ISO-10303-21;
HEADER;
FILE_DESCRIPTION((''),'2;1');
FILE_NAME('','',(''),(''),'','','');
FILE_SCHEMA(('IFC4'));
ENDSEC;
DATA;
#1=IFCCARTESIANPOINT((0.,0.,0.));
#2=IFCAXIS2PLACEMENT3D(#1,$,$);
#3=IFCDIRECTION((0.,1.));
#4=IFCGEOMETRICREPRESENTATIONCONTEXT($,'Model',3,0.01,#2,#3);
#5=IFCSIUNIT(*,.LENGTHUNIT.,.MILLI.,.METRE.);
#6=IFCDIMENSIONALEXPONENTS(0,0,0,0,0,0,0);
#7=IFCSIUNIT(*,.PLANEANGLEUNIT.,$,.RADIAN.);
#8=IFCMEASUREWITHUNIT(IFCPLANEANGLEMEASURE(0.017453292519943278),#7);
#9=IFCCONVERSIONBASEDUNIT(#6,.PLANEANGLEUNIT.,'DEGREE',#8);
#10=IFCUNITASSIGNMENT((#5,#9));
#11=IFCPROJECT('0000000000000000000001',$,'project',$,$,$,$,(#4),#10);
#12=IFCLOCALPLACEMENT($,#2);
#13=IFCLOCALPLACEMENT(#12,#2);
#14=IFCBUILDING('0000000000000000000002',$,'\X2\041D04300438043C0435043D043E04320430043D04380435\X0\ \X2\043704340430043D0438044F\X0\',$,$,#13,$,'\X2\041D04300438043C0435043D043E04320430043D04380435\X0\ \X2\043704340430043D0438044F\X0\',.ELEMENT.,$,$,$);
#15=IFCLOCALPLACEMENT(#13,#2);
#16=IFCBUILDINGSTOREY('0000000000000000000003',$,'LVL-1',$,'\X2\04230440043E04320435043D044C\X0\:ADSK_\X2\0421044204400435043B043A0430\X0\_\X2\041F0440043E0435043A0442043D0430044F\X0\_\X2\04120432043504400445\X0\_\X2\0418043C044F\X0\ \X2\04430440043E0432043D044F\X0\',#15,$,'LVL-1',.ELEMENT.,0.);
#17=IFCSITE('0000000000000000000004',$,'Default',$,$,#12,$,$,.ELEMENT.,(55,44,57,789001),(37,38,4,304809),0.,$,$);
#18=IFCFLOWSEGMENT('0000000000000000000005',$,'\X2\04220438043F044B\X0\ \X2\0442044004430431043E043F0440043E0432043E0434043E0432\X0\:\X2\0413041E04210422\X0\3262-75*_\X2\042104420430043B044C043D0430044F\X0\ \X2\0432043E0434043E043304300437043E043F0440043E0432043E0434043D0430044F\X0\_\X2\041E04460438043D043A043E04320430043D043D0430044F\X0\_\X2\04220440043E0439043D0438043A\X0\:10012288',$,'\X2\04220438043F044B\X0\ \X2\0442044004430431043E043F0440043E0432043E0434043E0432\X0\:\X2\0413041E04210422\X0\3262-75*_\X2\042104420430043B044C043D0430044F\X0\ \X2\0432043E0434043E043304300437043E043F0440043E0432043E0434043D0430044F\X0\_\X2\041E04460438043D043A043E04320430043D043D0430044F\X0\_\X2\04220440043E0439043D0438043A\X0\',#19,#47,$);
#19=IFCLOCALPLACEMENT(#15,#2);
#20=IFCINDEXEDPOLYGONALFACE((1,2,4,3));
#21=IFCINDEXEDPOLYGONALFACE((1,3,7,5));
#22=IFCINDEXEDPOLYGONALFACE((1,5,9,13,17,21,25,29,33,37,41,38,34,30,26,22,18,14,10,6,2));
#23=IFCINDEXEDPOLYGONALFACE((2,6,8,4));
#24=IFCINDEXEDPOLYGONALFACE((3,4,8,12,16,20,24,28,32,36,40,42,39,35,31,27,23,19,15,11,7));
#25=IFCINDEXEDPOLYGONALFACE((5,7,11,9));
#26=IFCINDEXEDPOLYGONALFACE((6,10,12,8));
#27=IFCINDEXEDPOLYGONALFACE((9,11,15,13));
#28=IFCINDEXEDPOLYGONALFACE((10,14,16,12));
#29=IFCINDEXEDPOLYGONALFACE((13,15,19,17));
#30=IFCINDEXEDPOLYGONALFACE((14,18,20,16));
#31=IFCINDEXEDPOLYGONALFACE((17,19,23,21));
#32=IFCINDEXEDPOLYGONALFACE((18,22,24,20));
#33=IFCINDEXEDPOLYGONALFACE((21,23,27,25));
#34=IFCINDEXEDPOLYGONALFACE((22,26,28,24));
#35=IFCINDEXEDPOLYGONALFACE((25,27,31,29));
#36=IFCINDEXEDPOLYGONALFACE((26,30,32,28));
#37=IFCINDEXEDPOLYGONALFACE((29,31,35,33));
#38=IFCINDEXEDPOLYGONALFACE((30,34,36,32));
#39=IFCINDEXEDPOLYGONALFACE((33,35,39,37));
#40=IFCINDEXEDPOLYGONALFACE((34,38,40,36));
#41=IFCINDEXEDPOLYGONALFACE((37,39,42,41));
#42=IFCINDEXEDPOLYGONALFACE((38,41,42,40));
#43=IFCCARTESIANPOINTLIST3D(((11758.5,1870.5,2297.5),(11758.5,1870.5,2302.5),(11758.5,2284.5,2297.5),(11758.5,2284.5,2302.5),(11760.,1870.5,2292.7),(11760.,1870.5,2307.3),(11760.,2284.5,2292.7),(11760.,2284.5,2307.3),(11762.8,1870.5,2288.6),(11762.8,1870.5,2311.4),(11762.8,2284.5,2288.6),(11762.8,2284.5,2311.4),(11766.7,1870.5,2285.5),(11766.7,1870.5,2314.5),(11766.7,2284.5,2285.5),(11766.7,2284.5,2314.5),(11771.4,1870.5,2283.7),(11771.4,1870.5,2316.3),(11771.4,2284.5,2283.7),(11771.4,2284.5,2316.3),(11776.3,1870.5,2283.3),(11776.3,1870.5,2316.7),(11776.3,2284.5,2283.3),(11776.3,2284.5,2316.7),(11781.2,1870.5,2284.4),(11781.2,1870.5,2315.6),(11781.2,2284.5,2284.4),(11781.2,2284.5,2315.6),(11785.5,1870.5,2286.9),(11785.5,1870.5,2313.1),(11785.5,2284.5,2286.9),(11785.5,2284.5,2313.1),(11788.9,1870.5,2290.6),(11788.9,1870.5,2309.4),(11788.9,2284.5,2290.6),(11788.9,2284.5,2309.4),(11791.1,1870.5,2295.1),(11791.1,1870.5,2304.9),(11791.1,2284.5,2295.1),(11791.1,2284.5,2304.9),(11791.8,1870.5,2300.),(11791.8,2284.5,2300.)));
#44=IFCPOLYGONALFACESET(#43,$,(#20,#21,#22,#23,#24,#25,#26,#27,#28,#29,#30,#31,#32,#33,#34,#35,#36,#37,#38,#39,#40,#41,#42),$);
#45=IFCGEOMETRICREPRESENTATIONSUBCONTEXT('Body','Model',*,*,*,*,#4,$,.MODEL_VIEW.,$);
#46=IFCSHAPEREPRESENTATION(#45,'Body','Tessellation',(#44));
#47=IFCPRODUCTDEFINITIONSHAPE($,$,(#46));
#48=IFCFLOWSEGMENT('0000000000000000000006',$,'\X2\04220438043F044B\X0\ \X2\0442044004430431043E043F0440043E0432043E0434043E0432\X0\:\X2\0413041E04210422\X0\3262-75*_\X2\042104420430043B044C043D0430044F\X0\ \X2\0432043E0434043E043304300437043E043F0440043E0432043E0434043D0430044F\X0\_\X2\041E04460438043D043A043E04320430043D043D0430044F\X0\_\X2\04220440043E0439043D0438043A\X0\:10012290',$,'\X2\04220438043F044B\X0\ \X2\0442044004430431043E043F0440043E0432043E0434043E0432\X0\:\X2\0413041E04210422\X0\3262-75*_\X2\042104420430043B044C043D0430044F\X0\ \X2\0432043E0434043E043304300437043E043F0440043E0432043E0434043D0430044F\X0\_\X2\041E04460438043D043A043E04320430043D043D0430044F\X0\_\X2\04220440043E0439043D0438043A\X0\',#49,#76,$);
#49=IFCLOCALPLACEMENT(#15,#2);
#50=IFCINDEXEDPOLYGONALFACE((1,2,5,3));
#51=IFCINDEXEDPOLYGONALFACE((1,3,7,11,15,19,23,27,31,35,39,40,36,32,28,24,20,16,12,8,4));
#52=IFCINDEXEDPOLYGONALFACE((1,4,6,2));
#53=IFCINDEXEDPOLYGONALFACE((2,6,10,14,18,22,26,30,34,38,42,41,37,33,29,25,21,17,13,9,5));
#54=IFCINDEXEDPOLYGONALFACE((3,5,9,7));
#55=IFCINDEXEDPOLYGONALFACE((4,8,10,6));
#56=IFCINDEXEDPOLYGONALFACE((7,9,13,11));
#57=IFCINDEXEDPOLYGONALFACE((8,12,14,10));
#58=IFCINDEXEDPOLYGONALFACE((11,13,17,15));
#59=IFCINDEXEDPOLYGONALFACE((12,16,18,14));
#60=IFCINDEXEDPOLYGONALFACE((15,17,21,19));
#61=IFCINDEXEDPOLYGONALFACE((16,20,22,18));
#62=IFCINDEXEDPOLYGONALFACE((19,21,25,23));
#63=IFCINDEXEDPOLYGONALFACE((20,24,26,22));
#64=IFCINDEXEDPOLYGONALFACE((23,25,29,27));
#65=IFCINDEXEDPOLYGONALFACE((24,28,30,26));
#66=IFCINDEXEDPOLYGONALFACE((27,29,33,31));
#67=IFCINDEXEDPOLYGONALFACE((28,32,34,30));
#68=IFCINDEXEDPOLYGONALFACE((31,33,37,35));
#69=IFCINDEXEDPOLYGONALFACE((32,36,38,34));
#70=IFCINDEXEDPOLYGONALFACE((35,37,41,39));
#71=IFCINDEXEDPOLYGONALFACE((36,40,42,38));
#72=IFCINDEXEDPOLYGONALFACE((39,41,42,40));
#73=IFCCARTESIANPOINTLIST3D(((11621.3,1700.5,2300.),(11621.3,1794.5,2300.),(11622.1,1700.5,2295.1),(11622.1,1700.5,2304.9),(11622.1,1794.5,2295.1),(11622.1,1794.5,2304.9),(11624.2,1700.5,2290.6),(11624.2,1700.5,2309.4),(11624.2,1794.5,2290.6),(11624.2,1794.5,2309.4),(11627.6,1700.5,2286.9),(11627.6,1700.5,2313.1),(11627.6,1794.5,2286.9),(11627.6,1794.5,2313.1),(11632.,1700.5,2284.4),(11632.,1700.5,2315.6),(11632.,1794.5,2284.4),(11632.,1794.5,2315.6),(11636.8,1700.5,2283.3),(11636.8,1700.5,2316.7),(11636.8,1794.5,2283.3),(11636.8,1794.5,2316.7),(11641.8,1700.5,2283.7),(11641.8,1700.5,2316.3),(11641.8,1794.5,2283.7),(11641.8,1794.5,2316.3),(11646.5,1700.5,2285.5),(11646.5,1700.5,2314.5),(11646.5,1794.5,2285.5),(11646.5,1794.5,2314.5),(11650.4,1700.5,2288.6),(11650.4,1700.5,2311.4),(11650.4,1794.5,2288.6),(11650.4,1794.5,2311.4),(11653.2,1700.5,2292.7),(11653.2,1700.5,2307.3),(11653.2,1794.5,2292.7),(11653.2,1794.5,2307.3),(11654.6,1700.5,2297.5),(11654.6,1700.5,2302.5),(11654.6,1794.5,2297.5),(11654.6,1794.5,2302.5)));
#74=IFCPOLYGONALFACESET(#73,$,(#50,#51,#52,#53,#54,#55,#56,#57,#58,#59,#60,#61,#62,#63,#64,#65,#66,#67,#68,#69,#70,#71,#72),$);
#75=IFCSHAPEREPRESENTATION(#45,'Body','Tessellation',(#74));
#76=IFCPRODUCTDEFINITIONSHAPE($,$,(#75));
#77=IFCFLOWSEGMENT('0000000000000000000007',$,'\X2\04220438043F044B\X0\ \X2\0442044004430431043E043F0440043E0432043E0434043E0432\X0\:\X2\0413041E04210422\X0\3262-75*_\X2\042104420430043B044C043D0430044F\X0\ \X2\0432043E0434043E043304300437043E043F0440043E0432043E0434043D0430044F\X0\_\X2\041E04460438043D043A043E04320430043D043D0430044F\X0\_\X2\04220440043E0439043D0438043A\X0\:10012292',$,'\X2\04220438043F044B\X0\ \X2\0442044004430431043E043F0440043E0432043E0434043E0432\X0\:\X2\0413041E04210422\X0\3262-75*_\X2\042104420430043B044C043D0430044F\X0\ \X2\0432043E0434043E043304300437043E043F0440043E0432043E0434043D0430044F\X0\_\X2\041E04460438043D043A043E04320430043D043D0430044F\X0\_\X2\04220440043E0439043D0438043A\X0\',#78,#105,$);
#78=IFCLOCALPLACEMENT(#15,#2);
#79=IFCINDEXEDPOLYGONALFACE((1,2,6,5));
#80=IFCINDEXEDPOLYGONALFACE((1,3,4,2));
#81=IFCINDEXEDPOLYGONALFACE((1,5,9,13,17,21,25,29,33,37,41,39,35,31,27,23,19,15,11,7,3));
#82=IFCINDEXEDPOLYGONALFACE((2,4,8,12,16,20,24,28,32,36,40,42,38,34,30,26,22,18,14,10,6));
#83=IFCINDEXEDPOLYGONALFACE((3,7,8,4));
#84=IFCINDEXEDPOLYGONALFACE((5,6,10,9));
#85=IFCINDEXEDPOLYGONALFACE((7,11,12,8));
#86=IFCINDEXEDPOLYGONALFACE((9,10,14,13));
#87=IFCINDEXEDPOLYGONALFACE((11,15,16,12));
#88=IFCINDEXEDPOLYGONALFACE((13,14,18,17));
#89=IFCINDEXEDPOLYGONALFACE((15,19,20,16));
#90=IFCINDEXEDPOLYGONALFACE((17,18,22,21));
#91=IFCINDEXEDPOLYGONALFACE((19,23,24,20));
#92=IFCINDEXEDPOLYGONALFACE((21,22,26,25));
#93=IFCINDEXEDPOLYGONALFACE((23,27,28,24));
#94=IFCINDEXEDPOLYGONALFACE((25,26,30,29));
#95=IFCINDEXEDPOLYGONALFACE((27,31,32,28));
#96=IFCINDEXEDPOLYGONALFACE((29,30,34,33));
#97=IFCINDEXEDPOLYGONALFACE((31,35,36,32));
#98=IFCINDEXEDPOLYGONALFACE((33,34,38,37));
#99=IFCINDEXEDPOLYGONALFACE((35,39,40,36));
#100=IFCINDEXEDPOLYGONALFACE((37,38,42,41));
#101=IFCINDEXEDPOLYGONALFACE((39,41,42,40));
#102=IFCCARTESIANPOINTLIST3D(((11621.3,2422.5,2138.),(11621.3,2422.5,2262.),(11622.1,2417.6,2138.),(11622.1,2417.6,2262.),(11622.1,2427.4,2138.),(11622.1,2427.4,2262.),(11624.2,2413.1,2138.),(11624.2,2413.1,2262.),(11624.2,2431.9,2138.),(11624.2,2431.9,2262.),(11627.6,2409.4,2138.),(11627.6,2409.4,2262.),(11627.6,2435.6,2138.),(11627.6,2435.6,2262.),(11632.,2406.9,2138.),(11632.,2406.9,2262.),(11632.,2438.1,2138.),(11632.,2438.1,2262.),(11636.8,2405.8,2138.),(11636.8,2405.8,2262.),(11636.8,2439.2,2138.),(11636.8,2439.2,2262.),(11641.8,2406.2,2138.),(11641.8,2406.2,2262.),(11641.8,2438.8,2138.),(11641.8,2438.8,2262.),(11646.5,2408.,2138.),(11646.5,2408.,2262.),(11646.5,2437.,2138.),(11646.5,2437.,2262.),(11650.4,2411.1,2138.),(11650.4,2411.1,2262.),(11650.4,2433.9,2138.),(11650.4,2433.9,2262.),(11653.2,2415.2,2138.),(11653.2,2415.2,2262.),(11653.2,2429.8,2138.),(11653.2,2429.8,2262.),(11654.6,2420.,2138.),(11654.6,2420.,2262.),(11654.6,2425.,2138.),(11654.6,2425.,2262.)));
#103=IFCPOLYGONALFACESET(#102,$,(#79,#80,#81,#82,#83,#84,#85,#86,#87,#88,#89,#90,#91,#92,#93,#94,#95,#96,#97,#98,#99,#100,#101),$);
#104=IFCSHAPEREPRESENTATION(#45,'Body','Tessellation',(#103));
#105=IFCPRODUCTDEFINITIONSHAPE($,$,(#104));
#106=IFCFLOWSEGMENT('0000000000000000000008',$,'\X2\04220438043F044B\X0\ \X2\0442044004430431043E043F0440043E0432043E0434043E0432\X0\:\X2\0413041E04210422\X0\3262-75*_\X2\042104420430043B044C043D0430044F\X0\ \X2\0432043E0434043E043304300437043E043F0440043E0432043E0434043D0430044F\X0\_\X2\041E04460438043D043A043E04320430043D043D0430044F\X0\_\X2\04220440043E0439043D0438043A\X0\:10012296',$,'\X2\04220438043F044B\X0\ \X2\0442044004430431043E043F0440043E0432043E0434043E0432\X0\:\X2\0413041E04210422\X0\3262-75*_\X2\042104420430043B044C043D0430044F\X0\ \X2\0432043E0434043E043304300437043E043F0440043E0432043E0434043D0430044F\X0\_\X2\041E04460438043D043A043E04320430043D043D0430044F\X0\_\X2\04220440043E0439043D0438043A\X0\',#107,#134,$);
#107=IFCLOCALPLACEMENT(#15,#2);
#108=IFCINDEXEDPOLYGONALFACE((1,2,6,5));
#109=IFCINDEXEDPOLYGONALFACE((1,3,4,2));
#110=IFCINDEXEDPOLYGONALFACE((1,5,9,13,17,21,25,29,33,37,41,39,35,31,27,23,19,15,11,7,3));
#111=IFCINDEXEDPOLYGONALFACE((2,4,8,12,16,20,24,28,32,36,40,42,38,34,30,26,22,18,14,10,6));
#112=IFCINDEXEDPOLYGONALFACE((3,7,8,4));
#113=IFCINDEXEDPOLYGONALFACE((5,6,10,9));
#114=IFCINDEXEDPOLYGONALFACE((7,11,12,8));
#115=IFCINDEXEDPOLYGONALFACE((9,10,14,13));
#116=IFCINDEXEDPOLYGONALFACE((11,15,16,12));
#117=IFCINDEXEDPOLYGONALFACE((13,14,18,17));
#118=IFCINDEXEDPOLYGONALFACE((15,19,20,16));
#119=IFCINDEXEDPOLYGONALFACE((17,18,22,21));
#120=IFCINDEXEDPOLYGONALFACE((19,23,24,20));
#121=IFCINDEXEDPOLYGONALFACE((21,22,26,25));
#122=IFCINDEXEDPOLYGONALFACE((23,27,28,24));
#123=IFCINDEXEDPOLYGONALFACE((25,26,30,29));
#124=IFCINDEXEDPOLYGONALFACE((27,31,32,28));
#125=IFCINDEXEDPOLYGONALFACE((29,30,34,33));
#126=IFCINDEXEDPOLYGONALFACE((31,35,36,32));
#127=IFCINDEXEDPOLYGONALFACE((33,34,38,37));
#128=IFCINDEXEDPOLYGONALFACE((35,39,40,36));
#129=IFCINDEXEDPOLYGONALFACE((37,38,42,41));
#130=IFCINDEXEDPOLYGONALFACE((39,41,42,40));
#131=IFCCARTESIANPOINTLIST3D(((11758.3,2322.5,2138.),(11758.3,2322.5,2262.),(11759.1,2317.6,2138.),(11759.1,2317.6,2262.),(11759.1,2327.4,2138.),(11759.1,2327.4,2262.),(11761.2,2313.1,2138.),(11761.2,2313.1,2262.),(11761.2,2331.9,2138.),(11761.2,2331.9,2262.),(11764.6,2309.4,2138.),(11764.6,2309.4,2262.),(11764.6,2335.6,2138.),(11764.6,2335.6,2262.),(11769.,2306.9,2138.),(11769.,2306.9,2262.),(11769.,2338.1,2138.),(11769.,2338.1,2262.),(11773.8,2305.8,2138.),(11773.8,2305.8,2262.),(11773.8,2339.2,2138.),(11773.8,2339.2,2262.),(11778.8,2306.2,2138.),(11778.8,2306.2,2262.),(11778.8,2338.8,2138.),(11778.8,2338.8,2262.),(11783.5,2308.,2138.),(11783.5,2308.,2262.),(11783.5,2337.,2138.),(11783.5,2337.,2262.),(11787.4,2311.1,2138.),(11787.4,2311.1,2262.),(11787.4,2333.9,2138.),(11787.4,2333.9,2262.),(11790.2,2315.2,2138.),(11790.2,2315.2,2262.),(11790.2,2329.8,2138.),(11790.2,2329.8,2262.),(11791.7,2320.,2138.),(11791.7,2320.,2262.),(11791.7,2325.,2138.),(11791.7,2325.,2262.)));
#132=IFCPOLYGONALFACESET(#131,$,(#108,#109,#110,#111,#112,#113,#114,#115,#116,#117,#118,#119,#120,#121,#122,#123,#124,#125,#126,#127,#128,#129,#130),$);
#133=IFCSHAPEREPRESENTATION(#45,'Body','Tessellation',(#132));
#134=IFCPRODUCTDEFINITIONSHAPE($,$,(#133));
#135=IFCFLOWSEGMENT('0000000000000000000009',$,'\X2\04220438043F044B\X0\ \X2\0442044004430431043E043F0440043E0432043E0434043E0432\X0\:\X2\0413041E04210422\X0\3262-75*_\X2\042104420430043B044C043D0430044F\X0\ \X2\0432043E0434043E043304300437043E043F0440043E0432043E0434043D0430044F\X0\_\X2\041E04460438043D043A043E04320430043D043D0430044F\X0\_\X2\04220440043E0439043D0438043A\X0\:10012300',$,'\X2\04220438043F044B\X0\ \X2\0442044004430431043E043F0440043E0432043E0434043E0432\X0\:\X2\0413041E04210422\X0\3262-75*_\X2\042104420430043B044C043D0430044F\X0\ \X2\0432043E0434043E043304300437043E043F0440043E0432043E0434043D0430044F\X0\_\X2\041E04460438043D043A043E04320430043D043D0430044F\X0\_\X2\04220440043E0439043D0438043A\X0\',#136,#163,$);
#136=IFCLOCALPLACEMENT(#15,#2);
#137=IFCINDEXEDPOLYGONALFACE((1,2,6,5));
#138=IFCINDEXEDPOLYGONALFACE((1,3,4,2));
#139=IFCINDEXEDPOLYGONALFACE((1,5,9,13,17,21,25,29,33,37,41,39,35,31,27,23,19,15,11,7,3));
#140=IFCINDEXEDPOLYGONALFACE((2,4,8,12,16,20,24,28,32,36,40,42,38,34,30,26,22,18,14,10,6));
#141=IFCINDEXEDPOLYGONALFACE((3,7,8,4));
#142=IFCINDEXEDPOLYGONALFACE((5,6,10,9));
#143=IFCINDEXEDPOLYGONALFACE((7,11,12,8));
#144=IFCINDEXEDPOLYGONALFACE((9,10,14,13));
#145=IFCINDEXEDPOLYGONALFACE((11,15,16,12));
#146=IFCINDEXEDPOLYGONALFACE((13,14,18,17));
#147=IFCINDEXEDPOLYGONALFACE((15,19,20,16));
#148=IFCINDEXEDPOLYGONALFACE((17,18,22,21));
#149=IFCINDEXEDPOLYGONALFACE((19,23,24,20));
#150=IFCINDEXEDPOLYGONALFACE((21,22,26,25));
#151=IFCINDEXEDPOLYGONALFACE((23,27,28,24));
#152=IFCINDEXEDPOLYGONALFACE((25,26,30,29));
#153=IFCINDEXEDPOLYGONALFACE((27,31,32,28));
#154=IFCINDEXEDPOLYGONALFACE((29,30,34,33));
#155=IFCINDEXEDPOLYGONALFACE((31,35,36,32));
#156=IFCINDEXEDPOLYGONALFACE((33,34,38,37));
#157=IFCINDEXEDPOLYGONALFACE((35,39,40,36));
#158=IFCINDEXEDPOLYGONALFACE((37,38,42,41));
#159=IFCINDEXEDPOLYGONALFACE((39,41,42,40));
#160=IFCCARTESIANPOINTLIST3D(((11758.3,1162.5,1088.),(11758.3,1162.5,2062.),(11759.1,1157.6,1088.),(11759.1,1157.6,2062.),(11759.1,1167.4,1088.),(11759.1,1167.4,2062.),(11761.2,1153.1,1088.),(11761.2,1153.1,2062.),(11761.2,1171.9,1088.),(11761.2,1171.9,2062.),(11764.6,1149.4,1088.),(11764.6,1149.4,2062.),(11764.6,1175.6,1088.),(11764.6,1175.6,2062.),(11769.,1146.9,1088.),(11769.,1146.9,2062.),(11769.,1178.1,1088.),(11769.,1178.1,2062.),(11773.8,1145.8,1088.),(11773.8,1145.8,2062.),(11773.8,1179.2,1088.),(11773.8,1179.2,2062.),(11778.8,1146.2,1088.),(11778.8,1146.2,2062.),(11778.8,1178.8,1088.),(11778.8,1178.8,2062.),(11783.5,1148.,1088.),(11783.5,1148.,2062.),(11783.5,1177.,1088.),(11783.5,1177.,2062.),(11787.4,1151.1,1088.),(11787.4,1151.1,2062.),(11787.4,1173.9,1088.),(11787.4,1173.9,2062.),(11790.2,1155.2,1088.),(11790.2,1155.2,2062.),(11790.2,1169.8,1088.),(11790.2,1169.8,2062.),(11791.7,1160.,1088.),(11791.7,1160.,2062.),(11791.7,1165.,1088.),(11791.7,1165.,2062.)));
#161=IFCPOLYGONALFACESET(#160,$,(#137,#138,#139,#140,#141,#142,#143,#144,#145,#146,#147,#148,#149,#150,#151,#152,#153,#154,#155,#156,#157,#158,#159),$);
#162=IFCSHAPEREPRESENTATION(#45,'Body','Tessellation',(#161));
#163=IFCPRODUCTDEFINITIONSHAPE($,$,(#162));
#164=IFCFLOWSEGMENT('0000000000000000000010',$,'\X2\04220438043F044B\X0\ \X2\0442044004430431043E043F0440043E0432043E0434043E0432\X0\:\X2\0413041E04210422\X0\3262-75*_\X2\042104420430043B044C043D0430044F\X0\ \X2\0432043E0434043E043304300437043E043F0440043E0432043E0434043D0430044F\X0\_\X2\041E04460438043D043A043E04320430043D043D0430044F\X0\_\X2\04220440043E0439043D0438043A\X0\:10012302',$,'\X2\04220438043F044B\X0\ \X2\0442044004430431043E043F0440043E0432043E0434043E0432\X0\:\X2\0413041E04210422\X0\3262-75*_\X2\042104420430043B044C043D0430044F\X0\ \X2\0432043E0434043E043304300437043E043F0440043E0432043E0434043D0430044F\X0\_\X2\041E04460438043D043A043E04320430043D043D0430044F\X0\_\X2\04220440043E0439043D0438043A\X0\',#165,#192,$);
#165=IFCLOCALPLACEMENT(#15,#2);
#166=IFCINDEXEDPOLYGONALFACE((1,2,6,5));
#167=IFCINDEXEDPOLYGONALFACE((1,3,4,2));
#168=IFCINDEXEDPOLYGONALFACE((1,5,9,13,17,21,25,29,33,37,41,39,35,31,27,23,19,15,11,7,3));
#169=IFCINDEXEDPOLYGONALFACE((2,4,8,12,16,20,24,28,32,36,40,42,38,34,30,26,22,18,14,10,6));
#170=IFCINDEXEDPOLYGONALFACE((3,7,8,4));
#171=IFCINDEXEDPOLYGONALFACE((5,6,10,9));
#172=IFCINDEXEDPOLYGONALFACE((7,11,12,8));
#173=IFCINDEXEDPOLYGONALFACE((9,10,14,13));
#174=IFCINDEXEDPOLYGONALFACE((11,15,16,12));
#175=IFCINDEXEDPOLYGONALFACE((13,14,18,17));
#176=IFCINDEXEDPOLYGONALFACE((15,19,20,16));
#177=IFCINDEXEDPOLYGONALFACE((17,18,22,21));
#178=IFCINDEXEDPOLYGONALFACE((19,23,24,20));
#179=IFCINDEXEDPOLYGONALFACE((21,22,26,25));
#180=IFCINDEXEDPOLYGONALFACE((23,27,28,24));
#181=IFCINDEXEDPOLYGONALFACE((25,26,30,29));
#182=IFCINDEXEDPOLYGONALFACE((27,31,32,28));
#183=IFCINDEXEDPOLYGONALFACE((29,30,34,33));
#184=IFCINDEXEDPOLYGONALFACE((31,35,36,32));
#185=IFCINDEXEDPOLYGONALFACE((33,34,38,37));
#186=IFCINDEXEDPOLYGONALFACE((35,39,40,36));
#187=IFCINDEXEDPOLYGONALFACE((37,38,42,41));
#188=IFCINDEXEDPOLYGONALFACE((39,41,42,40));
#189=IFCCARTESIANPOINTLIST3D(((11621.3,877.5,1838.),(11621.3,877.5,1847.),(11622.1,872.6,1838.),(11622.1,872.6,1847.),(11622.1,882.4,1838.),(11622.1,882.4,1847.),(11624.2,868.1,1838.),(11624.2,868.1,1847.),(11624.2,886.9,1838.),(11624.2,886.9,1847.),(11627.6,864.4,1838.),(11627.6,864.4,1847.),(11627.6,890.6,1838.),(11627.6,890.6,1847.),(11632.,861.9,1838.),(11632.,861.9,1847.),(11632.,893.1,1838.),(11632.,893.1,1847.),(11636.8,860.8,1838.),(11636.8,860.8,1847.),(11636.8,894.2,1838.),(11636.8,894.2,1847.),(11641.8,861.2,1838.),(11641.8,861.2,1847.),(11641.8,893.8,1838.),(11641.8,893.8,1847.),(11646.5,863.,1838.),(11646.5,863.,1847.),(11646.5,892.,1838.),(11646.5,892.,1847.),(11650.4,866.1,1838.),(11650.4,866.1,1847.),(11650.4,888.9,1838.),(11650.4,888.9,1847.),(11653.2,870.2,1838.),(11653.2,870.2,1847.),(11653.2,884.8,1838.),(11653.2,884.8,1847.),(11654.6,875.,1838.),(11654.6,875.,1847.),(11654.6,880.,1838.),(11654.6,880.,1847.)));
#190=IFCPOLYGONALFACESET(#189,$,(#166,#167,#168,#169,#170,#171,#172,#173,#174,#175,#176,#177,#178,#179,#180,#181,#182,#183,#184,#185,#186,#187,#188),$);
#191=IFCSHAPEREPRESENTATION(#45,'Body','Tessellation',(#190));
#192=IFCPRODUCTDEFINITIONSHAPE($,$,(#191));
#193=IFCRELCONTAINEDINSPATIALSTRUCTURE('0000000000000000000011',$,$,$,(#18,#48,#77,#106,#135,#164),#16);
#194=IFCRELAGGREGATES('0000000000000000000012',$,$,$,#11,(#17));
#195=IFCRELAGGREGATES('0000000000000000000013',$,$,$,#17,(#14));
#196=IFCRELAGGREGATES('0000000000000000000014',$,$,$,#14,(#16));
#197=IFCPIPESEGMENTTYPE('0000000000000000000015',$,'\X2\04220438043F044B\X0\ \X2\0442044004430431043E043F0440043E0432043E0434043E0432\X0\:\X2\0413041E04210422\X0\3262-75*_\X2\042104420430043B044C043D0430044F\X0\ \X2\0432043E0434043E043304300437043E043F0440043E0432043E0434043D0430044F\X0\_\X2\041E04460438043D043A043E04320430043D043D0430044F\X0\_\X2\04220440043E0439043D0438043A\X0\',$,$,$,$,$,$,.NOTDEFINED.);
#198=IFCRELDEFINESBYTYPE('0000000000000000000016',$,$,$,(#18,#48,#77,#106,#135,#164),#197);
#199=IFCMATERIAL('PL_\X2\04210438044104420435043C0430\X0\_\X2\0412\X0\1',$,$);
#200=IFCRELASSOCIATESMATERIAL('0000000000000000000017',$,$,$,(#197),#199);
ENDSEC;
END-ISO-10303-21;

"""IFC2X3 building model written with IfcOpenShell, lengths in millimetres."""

from ifc_helpers import new_model, entity, si_unit, converted_unit, direction, frame, origin, origin_2d_with_axis, place, context, subcontext, project, spatial, circle, extrude, material, type_object, element, save


model = new_model("IFC2X3")

# Units and contexts
model_context = context("Model", 3, precision=0.01, world=origin(), true_north=direction((0.0, 1.0)))
body_context = subcontext(model_context, "Body", "Model", "MODEL_VIEW")
ifc_project = project(units=[si_unit("LENGTHUNIT", "METRE", prefix="MILLI"), converted_unit("PLANEANGLEUNIT", "DEGREE", entity("IfcPlaneAngleMeasure", 0.017453292519943278), si_unit("PLANEANGLEUNIT", "RADIAN"), dimensions=[0, 0, 0, 0, 0, 0, 0])], contexts=[model_context])

# Site, building, storey
site_placement = place(None, origin())
site = spatial("IfcSite", under=ifc_project, at=site_placement, Name="Default", CompositionType="ELEMENT", RefLatitude=(55, 44, 57, 789001), RefLongitude=(37, 38, 4, 304809), RefElevation=0.0)
building_placement = place(site_placement, origin())
building = spatial("IfcBuilding", under=site, at=building_placement, Name="Наименование здания", LongName="Наименование здания", CompositionType="ELEMENT")
storey_placement = place(building_placement, origin())
storey = spatial("IfcBuildingStorey", under=building, at=storey_placement, Name="LVL-1", ObjectType="Уровень:ADSK_Стрелка_Проектная_Вверх_Имя уровня", LongName="LVL-1", CompositionType="ELEMENT", Elevation=0.0)

# Flow segments
ifc_material_1 = material(Name="PL_Система_В1")
pipe_segment_type_1 = type_object("IfcPipeSegmentType", Name="Типы трубопроводов:ГОСТ3262-75*_Стальная водогазопроводная_Оцинкованная_Тройник", PredefinedType="NOTDEFINED", material=ifc_material_1)
flow_segment_1_placement = place(storey_placement, origin())
element("IfcFlowSegment", 1, at=flow_segment_1_placement, inside=storey, type_object=pipe_segment_type_1, Name="Типы трубопроводов:ГОСТ3262-75*_Стальная водогазопроводная_Оцинкованная_Тройник:10012288", ObjectType="Типы трубопроводов:ГОСТ3262-75*_Стальная водогазопроводная_Оцинкованная_Тройник", context=body_context, shape_type="SweptSolid", body=[
    extrude(circle(Radius=16.8, at=origin_2d_with_axis()), frame((11775.1, 1870.5, 2300.0), z_axis=(0.0, 1.0, 0.0), x_axis=(1.0, 0.0, 0.0)), (0.0, 0.0, 1.0), 414.0),
])
flow_segment_2_placement = place(storey_placement, origin())
element("IfcFlowSegment", 2, at=flow_segment_2_placement, inside=storey, type_object=pipe_segment_type_1, Name="Типы трубопроводов:ГОСТ3262-75*_Стальная водогазопроводная_Оцинкованная_Тройник:10012290", ObjectType="Типы трубопроводов:ГОСТ3262-75*_Стальная водогазопроводная_Оцинкованная_Тройник", context=body_context, shape_type="SweptSolid", body=[
    extrude(circle(Radius=16.8, at=origin_2d_with_axis()), frame((11638.1, 1700.5, 2300.0), z_axis=(0.0, 1.0, 0.0), x_axis=(-1.0, 0.0, 0.0)), (0.0, 0.0, 1.0), 94.0),
])
flow_segment_3_placement = place(storey_placement, origin())
element("IfcFlowSegment", 3, at=flow_segment_3_placement, inside=storey, type_object=pipe_segment_type_1, Name="Типы трубопроводов:ГОСТ3262-75*_Стальная водогазопроводная_Оцинкованная_Тройник:10012292", ObjectType="Типы трубопроводов:ГОСТ3262-75*_Стальная водогазопроводная_Оцинкованная_Тройник", context=body_context, shape_type="SweptSolid", body=[
    extrude(circle(Radius=16.8, at=origin_2d_with_axis()), frame((11638.1, 2422.5, 2138.0), z_axis=(0.0, 0.0, 1.0), x_axis=(-1.0, 0.0, 0.0)), (0.0, 0.0, 1.0), 124.0),
])
flow_segment_4_placement = place(storey_placement, origin())
element("IfcFlowSegment", 4, at=flow_segment_4_placement, inside=storey, type_object=pipe_segment_type_1, Name="Типы трубопроводов:ГОСТ3262-75*_Стальная водогазопроводная_Оцинкованная_Тройник:10012296", ObjectType="Типы трубопроводов:ГОСТ3262-75*_Стальная водогазопроводная_Оцинкованная_Тройник", context=body_context, shape_type="SweptSolid", body=[
    extrude(circle(Radius=16.8, at=origin_2d_with_axis()), frame((11775.1, 2322.5, 2138.0), z_axis=(0.0, 0.0, 1.0), x_axis=(-1.0, 0.0, 0.0)), (0.0, 0.0, 1.0), 124.0),
])
flow_segment_5_placement = place(storey_placement, origin())
element("IfcFlowSegment", 5, at=flow_segment_5_placement, inside=storey, type_object=pipe_segment_type_1, Name="Типы трубопроводов:ГОСТ3262-75*_Стальная водогазопроводная_Оцинкованная_Тройник:10012300", ObjectType="Типы трубопроводов:ГОСТ3262-75*_Стальная водогазопроводная_Оцинкованная_Тройник", context=body_context, shape_type="SweptSolid", body=[
    extrude(circle(Radius=16.8, at=origin_2d_with_axis()), frame((11775.1, 1162.5, 1088.0), z_axis=(0.0, 0.0, 1.0), x_axis=(-1.0, 0.0, 0.0)), (0.0, 0.0, 1.0), 974.0),
])
flow_segment_6_placement = place(storey_placement, origin())
element("IfcFlowSegment", 6, at=flow_segment_6_placement, inside=storey, type_object=pipe_segment_type_1, Name="Типы трубопроводов:ГОСТ3262-75*_Стальная водогазопроводная_Оцинкованная_Тройник:10012302", ObjectType="Типы трубопроводов:ГОСТ3262-75*_Стальная водогазопроводная_Оцинкованная_Тройник", context=body_context, shape_type="SweptSolid", body=[
    extrude(circle(Radius=16.8, at=origin_2d_with_axis()), frame((11638.1, 877.5, 1838.0), z_axis=(0.0, 0.0, 1.0), x_axis=(-1.0, 0.0, 0.0)), (0.0, 0.0, 1.0), 9.0),
])

save(model, "model.ifc")
